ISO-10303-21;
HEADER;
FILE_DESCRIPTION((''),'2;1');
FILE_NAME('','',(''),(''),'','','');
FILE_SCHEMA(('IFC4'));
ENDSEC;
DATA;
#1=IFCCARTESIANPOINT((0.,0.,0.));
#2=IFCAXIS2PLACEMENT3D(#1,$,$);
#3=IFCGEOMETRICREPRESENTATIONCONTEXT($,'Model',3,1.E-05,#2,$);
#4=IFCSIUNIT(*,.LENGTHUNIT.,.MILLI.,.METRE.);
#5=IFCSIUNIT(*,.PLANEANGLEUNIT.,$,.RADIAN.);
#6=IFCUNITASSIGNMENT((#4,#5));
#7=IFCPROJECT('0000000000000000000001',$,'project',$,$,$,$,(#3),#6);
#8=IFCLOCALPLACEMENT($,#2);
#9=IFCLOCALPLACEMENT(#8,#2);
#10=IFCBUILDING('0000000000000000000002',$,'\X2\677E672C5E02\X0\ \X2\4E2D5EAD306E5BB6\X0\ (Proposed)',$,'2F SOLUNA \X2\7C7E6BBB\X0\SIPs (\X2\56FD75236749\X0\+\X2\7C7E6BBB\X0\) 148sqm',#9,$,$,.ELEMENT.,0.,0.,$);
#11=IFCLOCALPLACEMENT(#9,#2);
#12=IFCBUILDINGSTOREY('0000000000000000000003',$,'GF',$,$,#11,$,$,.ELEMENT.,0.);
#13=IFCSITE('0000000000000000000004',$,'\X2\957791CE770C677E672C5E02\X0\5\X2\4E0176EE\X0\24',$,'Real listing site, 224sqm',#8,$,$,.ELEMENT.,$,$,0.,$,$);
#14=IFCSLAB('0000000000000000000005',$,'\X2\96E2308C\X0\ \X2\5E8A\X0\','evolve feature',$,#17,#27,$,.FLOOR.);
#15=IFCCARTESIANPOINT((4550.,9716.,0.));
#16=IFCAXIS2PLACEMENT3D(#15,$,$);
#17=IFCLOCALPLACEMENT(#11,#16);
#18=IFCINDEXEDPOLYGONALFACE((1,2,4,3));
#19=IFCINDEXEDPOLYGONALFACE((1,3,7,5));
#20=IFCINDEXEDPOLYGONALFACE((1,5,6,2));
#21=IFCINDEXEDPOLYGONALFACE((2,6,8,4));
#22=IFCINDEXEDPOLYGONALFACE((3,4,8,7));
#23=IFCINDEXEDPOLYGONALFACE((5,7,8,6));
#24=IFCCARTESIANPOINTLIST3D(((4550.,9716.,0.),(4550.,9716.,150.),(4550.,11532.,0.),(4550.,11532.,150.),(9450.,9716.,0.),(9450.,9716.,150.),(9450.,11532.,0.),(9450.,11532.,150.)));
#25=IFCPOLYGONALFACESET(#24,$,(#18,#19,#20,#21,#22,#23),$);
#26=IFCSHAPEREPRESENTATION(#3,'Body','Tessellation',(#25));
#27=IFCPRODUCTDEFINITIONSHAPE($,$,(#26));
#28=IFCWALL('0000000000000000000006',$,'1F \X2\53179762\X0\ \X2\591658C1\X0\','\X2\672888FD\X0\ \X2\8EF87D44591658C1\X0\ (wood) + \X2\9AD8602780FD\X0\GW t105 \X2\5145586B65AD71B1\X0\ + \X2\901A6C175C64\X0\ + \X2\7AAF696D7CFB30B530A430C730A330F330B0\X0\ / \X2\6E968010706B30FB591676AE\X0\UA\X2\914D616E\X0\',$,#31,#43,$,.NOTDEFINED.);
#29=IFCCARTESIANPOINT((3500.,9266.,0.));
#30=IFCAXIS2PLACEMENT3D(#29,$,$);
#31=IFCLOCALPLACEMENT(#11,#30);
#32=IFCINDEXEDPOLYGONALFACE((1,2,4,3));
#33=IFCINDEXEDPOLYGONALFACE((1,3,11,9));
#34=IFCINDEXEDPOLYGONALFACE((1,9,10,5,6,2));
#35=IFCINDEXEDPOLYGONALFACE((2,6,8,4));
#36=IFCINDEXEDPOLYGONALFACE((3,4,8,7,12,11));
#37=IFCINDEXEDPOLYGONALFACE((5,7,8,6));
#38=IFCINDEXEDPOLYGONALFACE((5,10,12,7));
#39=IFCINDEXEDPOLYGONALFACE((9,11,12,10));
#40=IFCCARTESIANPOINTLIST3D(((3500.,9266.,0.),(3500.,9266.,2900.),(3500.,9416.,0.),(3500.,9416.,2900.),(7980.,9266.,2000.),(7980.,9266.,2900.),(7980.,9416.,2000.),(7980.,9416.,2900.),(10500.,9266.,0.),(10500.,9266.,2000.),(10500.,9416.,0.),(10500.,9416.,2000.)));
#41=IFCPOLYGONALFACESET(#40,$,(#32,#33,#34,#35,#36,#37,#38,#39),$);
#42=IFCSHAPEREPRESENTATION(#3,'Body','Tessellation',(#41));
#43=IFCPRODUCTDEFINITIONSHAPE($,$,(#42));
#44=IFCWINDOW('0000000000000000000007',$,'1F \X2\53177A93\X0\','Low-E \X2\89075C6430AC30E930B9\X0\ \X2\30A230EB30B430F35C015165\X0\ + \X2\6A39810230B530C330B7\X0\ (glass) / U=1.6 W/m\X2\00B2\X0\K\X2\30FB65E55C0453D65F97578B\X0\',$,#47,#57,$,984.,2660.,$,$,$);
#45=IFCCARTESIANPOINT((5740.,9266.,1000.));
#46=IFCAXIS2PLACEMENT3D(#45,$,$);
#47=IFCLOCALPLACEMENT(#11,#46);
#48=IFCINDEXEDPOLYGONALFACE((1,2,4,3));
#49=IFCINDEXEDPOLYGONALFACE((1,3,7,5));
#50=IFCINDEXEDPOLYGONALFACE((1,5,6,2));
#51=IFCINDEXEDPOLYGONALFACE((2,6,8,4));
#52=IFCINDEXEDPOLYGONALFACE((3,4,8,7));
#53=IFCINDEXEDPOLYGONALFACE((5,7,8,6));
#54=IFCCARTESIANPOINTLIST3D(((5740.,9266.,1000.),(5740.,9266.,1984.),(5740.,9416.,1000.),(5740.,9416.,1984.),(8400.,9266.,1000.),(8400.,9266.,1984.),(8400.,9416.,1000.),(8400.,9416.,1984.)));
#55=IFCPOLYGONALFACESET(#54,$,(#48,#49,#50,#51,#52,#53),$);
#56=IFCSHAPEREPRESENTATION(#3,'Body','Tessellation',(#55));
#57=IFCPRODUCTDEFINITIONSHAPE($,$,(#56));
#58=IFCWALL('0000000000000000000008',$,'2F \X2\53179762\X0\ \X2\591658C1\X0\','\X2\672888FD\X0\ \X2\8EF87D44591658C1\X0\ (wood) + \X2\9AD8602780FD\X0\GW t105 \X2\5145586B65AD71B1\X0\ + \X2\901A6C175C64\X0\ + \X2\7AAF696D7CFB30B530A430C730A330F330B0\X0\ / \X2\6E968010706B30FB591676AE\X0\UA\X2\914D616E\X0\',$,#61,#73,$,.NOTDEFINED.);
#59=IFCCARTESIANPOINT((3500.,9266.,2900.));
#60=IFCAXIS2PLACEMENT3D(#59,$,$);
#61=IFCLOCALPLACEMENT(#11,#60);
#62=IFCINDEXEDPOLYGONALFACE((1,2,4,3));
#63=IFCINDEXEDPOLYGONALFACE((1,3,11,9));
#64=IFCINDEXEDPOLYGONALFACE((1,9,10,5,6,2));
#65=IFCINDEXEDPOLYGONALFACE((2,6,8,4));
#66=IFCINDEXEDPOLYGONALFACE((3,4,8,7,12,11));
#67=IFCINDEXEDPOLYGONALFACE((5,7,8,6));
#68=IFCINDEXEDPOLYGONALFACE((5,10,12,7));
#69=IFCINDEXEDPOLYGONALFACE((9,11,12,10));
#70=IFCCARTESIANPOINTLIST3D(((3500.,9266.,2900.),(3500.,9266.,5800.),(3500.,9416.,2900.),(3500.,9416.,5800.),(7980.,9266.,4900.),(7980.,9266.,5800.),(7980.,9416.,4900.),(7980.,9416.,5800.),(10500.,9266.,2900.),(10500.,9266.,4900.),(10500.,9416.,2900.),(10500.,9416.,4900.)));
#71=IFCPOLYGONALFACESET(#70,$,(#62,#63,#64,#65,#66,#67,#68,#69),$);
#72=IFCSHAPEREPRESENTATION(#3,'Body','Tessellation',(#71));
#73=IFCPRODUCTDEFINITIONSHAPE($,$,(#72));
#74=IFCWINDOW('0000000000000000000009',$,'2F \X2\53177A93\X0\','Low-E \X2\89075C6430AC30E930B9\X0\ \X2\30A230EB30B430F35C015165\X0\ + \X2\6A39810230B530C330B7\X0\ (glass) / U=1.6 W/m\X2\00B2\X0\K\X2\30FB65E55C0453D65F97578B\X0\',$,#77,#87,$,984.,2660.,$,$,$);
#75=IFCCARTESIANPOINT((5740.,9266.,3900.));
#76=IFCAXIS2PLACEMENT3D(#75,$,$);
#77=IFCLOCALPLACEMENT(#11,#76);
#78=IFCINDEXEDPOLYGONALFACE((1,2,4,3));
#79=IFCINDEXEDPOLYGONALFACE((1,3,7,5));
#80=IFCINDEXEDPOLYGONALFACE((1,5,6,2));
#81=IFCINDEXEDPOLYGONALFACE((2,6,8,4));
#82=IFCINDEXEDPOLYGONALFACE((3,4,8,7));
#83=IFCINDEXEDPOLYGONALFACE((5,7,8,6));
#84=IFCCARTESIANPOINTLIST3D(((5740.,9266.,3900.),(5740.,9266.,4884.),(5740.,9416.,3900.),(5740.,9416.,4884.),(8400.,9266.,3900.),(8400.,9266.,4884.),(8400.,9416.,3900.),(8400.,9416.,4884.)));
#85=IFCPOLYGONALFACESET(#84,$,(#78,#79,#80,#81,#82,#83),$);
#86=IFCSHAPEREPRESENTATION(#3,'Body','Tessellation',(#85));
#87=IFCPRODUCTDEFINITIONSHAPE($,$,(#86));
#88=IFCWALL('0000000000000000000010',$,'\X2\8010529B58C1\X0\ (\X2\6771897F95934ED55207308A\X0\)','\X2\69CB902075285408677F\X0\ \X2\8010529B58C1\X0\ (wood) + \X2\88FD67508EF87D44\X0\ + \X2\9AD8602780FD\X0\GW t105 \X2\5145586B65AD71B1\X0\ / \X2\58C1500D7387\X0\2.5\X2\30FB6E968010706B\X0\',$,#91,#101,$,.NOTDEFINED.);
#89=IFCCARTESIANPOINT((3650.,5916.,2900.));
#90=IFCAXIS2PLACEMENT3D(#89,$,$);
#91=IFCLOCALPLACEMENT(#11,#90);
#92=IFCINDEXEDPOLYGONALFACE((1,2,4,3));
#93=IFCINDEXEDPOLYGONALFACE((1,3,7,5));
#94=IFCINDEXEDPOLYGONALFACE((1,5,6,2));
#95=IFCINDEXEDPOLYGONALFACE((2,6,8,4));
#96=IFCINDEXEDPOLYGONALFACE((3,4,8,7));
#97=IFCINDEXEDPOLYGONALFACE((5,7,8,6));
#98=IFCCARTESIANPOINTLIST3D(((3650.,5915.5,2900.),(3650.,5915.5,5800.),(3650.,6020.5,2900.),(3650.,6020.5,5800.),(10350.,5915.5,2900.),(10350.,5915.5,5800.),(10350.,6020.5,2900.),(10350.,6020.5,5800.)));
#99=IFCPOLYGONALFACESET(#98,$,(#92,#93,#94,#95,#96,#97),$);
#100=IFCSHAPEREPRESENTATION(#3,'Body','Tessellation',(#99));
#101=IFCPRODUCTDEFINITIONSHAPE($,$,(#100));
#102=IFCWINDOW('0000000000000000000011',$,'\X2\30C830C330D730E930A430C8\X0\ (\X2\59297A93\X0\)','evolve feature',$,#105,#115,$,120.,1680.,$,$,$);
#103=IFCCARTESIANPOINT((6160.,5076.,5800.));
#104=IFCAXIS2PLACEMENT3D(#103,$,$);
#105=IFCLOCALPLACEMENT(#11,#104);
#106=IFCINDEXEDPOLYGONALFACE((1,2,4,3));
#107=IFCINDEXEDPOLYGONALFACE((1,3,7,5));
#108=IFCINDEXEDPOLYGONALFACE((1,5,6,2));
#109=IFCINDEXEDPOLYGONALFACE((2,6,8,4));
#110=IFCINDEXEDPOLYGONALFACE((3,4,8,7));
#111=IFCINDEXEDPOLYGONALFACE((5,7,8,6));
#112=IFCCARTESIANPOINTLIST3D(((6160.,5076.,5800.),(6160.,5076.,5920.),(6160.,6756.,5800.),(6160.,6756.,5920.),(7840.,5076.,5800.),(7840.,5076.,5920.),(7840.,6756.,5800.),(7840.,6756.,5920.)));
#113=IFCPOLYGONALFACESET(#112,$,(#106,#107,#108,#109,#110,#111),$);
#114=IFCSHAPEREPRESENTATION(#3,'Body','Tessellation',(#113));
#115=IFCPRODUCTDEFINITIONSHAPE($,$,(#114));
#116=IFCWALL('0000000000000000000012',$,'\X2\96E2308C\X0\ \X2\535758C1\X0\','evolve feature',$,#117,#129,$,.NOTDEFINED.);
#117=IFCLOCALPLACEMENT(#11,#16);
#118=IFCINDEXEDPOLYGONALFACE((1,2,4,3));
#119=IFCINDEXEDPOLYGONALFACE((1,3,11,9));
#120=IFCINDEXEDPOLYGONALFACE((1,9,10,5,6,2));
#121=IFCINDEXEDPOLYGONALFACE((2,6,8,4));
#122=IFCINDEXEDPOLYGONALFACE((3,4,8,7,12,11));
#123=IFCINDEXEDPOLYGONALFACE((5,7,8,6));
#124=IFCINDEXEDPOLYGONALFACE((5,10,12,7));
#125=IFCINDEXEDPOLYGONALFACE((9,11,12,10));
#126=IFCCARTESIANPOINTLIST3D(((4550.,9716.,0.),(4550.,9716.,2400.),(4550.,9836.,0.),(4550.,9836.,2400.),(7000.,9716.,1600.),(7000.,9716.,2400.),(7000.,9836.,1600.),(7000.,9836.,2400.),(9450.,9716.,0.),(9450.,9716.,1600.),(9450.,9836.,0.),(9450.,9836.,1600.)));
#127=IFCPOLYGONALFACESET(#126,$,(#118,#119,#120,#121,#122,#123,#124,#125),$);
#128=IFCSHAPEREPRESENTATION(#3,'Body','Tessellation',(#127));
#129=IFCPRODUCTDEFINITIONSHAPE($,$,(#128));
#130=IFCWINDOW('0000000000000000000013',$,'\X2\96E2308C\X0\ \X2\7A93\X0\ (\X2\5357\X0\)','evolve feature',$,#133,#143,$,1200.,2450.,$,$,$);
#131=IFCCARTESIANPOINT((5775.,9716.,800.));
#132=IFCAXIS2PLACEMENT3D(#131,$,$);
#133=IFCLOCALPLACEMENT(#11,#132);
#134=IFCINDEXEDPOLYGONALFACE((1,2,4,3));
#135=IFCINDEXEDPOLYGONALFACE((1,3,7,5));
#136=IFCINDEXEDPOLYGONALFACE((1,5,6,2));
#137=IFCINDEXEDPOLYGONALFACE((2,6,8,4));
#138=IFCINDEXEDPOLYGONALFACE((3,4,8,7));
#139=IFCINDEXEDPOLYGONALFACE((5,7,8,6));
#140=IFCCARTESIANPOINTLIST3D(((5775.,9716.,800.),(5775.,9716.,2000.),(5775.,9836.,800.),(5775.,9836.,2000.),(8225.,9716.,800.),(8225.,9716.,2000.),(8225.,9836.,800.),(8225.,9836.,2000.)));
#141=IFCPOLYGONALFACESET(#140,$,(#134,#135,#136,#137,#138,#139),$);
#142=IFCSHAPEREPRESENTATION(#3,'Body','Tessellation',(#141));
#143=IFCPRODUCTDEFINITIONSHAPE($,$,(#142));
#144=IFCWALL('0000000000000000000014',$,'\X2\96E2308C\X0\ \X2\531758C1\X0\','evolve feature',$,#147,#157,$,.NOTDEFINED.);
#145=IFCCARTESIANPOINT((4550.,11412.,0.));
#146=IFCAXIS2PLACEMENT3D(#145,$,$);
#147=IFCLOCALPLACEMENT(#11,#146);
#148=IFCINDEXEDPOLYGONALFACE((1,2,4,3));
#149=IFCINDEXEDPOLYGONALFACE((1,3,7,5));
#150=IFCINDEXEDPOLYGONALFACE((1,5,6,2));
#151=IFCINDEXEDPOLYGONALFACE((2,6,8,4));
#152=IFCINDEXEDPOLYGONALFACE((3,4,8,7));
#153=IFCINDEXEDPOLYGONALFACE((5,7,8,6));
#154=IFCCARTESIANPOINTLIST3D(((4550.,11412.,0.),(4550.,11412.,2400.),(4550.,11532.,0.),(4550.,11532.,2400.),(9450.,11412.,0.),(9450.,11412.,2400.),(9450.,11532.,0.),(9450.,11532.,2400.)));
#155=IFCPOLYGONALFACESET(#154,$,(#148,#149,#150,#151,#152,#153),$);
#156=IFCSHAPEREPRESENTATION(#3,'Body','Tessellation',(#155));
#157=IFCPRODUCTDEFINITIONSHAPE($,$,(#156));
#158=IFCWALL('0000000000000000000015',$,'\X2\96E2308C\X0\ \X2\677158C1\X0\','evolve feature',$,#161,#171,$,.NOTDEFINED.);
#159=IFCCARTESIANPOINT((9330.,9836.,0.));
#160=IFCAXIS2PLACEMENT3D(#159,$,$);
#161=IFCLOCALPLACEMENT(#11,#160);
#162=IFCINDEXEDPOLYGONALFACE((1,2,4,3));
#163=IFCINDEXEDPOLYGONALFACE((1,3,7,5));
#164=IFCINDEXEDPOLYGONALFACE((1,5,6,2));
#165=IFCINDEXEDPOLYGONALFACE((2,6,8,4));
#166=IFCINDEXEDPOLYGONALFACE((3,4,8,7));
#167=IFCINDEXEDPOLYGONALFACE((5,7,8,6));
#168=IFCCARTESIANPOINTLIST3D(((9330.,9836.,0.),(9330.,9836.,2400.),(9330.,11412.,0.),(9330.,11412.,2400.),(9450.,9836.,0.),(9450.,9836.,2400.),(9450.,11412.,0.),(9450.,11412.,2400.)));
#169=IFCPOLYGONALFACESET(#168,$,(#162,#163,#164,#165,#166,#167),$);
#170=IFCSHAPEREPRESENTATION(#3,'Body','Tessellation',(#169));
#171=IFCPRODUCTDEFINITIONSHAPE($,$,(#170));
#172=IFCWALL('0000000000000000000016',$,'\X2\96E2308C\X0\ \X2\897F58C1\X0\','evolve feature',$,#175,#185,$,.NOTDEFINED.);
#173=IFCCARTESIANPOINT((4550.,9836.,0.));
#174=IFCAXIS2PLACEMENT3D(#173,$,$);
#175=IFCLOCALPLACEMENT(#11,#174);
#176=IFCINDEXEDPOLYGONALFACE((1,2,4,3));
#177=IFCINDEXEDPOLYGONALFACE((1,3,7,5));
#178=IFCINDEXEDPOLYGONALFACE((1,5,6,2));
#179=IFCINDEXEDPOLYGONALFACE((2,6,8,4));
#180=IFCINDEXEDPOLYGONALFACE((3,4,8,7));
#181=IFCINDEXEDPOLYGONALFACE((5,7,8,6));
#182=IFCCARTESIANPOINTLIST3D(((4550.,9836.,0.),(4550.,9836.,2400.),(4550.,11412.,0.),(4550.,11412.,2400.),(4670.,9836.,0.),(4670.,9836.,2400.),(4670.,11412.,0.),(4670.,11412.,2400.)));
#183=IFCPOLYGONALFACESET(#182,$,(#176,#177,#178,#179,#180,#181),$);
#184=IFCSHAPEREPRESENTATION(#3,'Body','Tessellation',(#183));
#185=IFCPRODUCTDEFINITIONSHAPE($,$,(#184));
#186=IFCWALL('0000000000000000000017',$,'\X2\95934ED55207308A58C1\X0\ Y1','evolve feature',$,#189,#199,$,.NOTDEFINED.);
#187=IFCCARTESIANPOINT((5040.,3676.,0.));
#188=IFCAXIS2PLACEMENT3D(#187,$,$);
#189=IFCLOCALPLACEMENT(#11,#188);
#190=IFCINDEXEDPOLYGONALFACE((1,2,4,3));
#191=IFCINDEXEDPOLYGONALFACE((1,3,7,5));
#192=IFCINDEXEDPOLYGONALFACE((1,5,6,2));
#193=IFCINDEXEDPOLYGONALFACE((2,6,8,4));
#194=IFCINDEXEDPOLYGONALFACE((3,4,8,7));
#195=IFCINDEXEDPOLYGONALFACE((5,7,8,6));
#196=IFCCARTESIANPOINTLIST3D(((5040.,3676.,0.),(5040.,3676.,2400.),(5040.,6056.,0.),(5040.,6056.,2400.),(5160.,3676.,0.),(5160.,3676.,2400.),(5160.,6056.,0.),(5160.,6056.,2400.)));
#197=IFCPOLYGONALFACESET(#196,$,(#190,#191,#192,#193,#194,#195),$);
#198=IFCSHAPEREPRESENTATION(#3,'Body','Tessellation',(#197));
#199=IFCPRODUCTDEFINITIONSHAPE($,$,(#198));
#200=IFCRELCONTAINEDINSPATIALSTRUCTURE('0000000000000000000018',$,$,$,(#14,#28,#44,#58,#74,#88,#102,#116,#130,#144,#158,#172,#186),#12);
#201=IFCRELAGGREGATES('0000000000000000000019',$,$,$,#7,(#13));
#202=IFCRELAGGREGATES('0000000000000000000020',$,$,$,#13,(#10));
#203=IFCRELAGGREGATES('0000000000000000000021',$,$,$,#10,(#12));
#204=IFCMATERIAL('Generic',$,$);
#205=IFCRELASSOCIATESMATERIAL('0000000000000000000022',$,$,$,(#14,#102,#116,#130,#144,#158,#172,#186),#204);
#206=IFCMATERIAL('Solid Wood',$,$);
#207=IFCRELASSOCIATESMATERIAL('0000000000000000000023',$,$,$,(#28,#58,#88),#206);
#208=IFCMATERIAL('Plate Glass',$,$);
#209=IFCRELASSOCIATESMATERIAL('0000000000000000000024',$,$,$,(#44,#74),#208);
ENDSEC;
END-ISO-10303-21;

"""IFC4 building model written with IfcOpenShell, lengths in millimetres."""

from ifc_helpers import new_model, si_unit, frame, frame_2d, origin, place, context, project, spatial, rectangle, extrude, material, element, fill, save


model = new_model("IFC4")

# Units and contexts
model_context = context("Model", 3, precision=1e-05, world=origin())
ifc_project = project(units=[si_unit("LENGTHUNIT", "METRE", prefix="MILLI"), si_unit("PLANEANGLEUNIT", "RADIAN")], contexts=[model_context])

# Site, building, storey
site_placement = place(None, origin())
site = spatial("IfcSite", under=ifc_project, at=site_placement, Name="長野県松本市5丁目24", ObjectType="Real listing site, 224sqm", CompositionType="ELEMENT", RefElevation=0.0)
building_placement = place(site_placement, origin())
building = spatial("IfcBuilding", under=site, at=building_placement, Name="松本市 中庭の家 (Proposed)", ObjectType="2F SOLUNA 籾殻SIPs (国産杉+籾殻) 148sqm", CompositionType="ELEMENT", ElevationOfRefHeight=0.0, ElevationOfTerrain=0.0)
storey_placement = place(building_placement, origin())
storey = spatial("IfcBuildingStorey", under=building, at=storey_placement, Name="GF", CompositionType="ELEMENT", Elevation=0.0)

# Slab
ifc_material_1 = material(Name="Generic")
slab_placement = place(storey_placement, frame((4550.0, 9716.0, 0.0)))
element("IfcSlab", 1, at=slab_placement, inside=storey, material=ifc_material_1, Name="離れ 床", Description="evolve feature", PredefinedType="FLOOR", context=model_context, shape_type="SweptSolid", body=[
    extrude(rectangle(XDim=4900.0, YDim=1816.0, at=frame_2d((2450.0, 908.0))), frame((4550.0, 9716.0, 0.0)), (0.0, 0.0, 1.0), 150.0),
])

# Wall, opening, window
ifc_material_2 = material(Name="Solid Wood")
wall_1_placement = place(storey_placement, frame((3500.0, 9266.0, 0.0)))
wall_1 = element("IfcWall", 2, at=wall_1_placement, inside=storey, material=ifc_material_2, Name="1F 北面 外壁", Description="木製 軸組外壁 (wood) + 高性能GW t105 充填断熱 + 通気層 + 窯業系サイディング / 準耐火・外皮UA配慮", PredefinedType="NOTDEFINED", context=model_context, shape_type="SweptSolid", body=[
    extrude(rectangle(XDim=7000.0, YDim=150.0, at=frame_2d((3500.0, 75.0))), frame((3500.0, 9266.0, 0.0)), (0.0, 0.0, 1.0), 2900.0),
])
opening_1_placement = place(storey_placement, frame((5740.0, 9266.0, 1000.0)))
opening_1 = element("IfcOpeningElement", 3, at=opening_1_placement, cuts=wall_1, PredefinedType="NOTDEFINED", context=model_context, shape_type="SweptSolid", body=[
    extrude(rectangle(XDim=2660.0, YDim=150.0, at=frame_2d((1330.0, 75.0))), frame((5740.0, 9266.0, 1000.0)), (0.0, 0.0, 1.0), 984.0),
])
ifc_material_3 = material(Name="Plate Glass")
window_1_placement = place(storey_placement, frame((5740.0, 9266.0, 1000.0)))
window_1 = element("IfcWindow", 4, at=window_1_placement, inside=storey, material=ifc_material_3, Name="1F 北窓", Description="Low-E 複層ガラス アルゴン封入 + 樹脂サッシ (glass) / U=1.6 W/m²K・日射取得型", OverallHeight=984.0, OverallWidth=2660.0, context=model_context, shape_type="SweptSolid", body=[
    extrude(rectangle(XDim=2660.0, YDim=150.0, at=frame_2d((1330.0, 75.0))), frame((5740.0, 9266.0, 1000.0)), (0.0, 0.0, 1.0), 984.0),
])
fill(opening_1, window_1)

# Wall, opening, window
wall_2_placement = place(storey_placement, frame((3500.0, 9266.0, 2900.0)))
wall_2 = element("IfcWall", 5, at=wall_2_placement, inside=storey, material=ifc_material_2, Name="2F 北面 外壁", Description="木製 軸組外壁 (wood) + 高性能GW t105 充填断熱 + 通気層 + 窯業系サイディング / 準耐火・外皮UA配慮", PredefinedType="NOTDEFINED", context=model_context, shape_type="SweptSolid", body=[
    extrude(rectangle(XDim=7000.0, YDim=150.0, at=frame_2d((3500.0, 75.0))), frame((3500.0, 9266.0, 2900.0)), (0.0, 0.0, 1.0), 2900.0),
])
opening_2_placement = place(storey_placement, frame((5740.0, 9266.0, 3900.0)))
opening_2 = element("IfcOpeningElement", 6, at=opening_2_placement, cuts=wall_2, PredefinedType="NOTDEFINED", context=model_context, shape_type="SweptSolid", body=[
    extrude(rectangle(XDim=2660.0, YDim=150.0, at=frame_2d((1330.0, 75.0))), frame((5740.0, 9266.0, 3900.0)), (0.0, 0.0, 1.0), 984.0),
])
window_2_placement = place(storey_placement, frame((5740.0, 9266.0, 3900.0)))
window_2 = element("IfcWindow", 7, at=window_2_placement, inside=storey, material=ifc_material_3, Name="2F 北窓", Description="Low-E 複層ガラス アルゴン封入 + 樹脂サッシ (glass) / U=1.6 W/m²K・日射取得型", OverallHeight=984.0, OverallWidth=2660.0, context=model_context, shape_type="SweptSolid", body=[
    extrude(rectangle(XDim=2660.0, YDim=150.0, at=frame_2d((1330.0, 75.0))), frame((5740.0, 9266.0, 3900.0)), (0.0, 0.0, 1.0), 984.0),
])
fill(opening_2, window_2)

# Wall
wall_3_placement = place(storey_placement, frame((3650.0, 5916.0, 2900.0)))
element("IfcWall", 8, at=wall_3_placement, inside=storey, material=ifc_material_2, Name="耐力壁 (東西間仕切り)", Description="構造用合板 耐力壁 (wood) + 製材軸組 + 高性能GW t105 充填断熱 / 壁倍率2.5・準耐火", PredefinedType="NOTDEFINED", context=model_context, shape_type="SweptSolid", body=[
    extrude(rectangle(XDim=6700.0, YDim=105.0, at=frame_2d((3350.0, 52.0))), frame((3650.0, 5916.0, 2900.0)), (0.0, 0.0, 1.0), 2900.0),
])

# Window
window_3_placement = place(storey_placement, frame((6160.0, 5076.0, 5800.0)))
element("IfcWindow", 9, at=window_3_placement, inside=storey, material=ifc_material_1, Name="トップライト (天窓)", Description="evolve feature", OverallHeight=120.0, OverallWidth=1680.0, context=model_context, shape_type="SweptSolid", body=[
    extrude(rectangle(XDim=1680.0, YDim=1680.0, at=frame_2d((840.0, 840.0))), frame((6160.0, 5076.0, 5800.0)), (0.0, 0.0, 1.0), 120.0),
])

# Wall, opening, window
wall_4_placement = place(storey_placement, frame((4550.0, 9716.0, 0.0)))
wall_4 = element("IfcWall", 10, at=wall_4_placement, inside=storey, material=ifc_material_1, Name="離れ 南壁", Description="evolve feature", PredefinedType="NOTDEFINED", context=model_context, shape_type="SweptSolid", body=[
    extrude(rectangle(XDim=4900.0, YDim=120.0, at=frame_2d((2450.0, 60.0))), frame((4550.0, 9716.0, 0.0)), (0.0, 0.0, 1.0), 2400.0),
])
opening_3_placement = place(storey_placement, frame((5775.0, 9716.0, 800.0)))
opening_3 = element("IfcOpeningElement", 11, at=opening_3_placement, cuts=wall_4, PredefinedType="NOTDEFINED", context=model_context, shape_type="SweptSolid", body=[
    extrude(rectangle(XDim=2450.0, YDim=120.0, at=frame_2d((1225.0, 60.0))), frame((5775.0, 9716.0, 800.0)), (0.0, 0.0, 1.0), 1200.0),
])
window_4_placement = place(storey_placement, frame((5775.0, 9716.0, 800.0)))
window_4 = element("IfcWindow", 12, at=window_4_placement, inside=storey, material=ifc_material_1, Name="離れ 窓 (南)", Description="evolve feature", OverallHeight=1200.0, OverallWidth=2450.0, context=model_context, shape_type="SweptSolid", body=[
    extrude(rectangle(XDim=2450.0, YDim=120.0, at=frame_2d((1225.0, 60.0))), frame((5775.0, 9716.0, 800.0)), (0.0, 0.0, 1.0), 1200.0),
])
fill(opening_3, window_4)

# Walls
wall_5_placement = place(storey_placement, frame((4550.0, 11412.0, 0.0)))
element("IfcWall", 13, at=wall_5_placement, inside=storey, material=ifc_material_1, Name="離れ 北壁", Description="evolve feature", PredefinedType="NOTDEFINED", context=model_context, shape_type="SweptSolid", body=[
    extrude(rectangle(XDim=4900.0, YDim=120.0, at=frame_2d((2450.0, 60.0))), frame((4550.0, 11412.0, 0.0)), (0.0, 0.0, 1.0), 2400.0),
])
wall_6_placement = place(storey_placement, frame((9330.0, 9836.0, 0.0)))
element("IfcWall", 14, at=wall_6_placement, inside=storey, material=ifc_material_1, Name="離れ 東壁", Description="evolve feature", PredefinedType="NOTDEFINED", context=model_context, shape_type="SweptSolid", body=[
    extrude(rectangle(XDim=120.0, YDim=1576.0, at=frame_2d((60.0, 788.0))), frame((9330.0, 9836.0, 0.0)), (0.0, 0.0, 1.0), 2400.0),
])
wall_7_placement = place(storey_placement, frame((4550.0, 9836.0, 0.0)))
element("IfcWall", 15, at=wall_7_placement, inside=storey, material=ifc_material_1, Name="離れ 西壁", Description="evolve feature", PredefinedType="NOTDEFINED", context=model_context, shape_type="SweptSolid", body=[
    extrude(rectangle(XDim=120.0, YDim=1576.0, at=frame_2d((60.0, 788.0))), frame((4550.0, 9836.0, 0.0)), (0.0, 0.0, 1.0), 2400.0),
])
wall_8_placement = place(storey_placement, frame((5040.0, 3676.0, 0.0)))
element("IfcWall", 16, at=wall_8_placement, inside=storey, material=ifc_material_1, Name="間仕切り壁 Y1", Description="evolve feature", PredefinedType="NOTDEFINED", context=model_context, shape_type="SweptSolid", body=[
    extrude(rectangle(XDim=120.0, YDim=2380.0, at=frame_2d((60.0, 1190.0))), frame((5040.0, 3676.0, 0.0)), (0.0, 0.0, 1.0), 2400.0),
])

save(model, "model.ifc")
